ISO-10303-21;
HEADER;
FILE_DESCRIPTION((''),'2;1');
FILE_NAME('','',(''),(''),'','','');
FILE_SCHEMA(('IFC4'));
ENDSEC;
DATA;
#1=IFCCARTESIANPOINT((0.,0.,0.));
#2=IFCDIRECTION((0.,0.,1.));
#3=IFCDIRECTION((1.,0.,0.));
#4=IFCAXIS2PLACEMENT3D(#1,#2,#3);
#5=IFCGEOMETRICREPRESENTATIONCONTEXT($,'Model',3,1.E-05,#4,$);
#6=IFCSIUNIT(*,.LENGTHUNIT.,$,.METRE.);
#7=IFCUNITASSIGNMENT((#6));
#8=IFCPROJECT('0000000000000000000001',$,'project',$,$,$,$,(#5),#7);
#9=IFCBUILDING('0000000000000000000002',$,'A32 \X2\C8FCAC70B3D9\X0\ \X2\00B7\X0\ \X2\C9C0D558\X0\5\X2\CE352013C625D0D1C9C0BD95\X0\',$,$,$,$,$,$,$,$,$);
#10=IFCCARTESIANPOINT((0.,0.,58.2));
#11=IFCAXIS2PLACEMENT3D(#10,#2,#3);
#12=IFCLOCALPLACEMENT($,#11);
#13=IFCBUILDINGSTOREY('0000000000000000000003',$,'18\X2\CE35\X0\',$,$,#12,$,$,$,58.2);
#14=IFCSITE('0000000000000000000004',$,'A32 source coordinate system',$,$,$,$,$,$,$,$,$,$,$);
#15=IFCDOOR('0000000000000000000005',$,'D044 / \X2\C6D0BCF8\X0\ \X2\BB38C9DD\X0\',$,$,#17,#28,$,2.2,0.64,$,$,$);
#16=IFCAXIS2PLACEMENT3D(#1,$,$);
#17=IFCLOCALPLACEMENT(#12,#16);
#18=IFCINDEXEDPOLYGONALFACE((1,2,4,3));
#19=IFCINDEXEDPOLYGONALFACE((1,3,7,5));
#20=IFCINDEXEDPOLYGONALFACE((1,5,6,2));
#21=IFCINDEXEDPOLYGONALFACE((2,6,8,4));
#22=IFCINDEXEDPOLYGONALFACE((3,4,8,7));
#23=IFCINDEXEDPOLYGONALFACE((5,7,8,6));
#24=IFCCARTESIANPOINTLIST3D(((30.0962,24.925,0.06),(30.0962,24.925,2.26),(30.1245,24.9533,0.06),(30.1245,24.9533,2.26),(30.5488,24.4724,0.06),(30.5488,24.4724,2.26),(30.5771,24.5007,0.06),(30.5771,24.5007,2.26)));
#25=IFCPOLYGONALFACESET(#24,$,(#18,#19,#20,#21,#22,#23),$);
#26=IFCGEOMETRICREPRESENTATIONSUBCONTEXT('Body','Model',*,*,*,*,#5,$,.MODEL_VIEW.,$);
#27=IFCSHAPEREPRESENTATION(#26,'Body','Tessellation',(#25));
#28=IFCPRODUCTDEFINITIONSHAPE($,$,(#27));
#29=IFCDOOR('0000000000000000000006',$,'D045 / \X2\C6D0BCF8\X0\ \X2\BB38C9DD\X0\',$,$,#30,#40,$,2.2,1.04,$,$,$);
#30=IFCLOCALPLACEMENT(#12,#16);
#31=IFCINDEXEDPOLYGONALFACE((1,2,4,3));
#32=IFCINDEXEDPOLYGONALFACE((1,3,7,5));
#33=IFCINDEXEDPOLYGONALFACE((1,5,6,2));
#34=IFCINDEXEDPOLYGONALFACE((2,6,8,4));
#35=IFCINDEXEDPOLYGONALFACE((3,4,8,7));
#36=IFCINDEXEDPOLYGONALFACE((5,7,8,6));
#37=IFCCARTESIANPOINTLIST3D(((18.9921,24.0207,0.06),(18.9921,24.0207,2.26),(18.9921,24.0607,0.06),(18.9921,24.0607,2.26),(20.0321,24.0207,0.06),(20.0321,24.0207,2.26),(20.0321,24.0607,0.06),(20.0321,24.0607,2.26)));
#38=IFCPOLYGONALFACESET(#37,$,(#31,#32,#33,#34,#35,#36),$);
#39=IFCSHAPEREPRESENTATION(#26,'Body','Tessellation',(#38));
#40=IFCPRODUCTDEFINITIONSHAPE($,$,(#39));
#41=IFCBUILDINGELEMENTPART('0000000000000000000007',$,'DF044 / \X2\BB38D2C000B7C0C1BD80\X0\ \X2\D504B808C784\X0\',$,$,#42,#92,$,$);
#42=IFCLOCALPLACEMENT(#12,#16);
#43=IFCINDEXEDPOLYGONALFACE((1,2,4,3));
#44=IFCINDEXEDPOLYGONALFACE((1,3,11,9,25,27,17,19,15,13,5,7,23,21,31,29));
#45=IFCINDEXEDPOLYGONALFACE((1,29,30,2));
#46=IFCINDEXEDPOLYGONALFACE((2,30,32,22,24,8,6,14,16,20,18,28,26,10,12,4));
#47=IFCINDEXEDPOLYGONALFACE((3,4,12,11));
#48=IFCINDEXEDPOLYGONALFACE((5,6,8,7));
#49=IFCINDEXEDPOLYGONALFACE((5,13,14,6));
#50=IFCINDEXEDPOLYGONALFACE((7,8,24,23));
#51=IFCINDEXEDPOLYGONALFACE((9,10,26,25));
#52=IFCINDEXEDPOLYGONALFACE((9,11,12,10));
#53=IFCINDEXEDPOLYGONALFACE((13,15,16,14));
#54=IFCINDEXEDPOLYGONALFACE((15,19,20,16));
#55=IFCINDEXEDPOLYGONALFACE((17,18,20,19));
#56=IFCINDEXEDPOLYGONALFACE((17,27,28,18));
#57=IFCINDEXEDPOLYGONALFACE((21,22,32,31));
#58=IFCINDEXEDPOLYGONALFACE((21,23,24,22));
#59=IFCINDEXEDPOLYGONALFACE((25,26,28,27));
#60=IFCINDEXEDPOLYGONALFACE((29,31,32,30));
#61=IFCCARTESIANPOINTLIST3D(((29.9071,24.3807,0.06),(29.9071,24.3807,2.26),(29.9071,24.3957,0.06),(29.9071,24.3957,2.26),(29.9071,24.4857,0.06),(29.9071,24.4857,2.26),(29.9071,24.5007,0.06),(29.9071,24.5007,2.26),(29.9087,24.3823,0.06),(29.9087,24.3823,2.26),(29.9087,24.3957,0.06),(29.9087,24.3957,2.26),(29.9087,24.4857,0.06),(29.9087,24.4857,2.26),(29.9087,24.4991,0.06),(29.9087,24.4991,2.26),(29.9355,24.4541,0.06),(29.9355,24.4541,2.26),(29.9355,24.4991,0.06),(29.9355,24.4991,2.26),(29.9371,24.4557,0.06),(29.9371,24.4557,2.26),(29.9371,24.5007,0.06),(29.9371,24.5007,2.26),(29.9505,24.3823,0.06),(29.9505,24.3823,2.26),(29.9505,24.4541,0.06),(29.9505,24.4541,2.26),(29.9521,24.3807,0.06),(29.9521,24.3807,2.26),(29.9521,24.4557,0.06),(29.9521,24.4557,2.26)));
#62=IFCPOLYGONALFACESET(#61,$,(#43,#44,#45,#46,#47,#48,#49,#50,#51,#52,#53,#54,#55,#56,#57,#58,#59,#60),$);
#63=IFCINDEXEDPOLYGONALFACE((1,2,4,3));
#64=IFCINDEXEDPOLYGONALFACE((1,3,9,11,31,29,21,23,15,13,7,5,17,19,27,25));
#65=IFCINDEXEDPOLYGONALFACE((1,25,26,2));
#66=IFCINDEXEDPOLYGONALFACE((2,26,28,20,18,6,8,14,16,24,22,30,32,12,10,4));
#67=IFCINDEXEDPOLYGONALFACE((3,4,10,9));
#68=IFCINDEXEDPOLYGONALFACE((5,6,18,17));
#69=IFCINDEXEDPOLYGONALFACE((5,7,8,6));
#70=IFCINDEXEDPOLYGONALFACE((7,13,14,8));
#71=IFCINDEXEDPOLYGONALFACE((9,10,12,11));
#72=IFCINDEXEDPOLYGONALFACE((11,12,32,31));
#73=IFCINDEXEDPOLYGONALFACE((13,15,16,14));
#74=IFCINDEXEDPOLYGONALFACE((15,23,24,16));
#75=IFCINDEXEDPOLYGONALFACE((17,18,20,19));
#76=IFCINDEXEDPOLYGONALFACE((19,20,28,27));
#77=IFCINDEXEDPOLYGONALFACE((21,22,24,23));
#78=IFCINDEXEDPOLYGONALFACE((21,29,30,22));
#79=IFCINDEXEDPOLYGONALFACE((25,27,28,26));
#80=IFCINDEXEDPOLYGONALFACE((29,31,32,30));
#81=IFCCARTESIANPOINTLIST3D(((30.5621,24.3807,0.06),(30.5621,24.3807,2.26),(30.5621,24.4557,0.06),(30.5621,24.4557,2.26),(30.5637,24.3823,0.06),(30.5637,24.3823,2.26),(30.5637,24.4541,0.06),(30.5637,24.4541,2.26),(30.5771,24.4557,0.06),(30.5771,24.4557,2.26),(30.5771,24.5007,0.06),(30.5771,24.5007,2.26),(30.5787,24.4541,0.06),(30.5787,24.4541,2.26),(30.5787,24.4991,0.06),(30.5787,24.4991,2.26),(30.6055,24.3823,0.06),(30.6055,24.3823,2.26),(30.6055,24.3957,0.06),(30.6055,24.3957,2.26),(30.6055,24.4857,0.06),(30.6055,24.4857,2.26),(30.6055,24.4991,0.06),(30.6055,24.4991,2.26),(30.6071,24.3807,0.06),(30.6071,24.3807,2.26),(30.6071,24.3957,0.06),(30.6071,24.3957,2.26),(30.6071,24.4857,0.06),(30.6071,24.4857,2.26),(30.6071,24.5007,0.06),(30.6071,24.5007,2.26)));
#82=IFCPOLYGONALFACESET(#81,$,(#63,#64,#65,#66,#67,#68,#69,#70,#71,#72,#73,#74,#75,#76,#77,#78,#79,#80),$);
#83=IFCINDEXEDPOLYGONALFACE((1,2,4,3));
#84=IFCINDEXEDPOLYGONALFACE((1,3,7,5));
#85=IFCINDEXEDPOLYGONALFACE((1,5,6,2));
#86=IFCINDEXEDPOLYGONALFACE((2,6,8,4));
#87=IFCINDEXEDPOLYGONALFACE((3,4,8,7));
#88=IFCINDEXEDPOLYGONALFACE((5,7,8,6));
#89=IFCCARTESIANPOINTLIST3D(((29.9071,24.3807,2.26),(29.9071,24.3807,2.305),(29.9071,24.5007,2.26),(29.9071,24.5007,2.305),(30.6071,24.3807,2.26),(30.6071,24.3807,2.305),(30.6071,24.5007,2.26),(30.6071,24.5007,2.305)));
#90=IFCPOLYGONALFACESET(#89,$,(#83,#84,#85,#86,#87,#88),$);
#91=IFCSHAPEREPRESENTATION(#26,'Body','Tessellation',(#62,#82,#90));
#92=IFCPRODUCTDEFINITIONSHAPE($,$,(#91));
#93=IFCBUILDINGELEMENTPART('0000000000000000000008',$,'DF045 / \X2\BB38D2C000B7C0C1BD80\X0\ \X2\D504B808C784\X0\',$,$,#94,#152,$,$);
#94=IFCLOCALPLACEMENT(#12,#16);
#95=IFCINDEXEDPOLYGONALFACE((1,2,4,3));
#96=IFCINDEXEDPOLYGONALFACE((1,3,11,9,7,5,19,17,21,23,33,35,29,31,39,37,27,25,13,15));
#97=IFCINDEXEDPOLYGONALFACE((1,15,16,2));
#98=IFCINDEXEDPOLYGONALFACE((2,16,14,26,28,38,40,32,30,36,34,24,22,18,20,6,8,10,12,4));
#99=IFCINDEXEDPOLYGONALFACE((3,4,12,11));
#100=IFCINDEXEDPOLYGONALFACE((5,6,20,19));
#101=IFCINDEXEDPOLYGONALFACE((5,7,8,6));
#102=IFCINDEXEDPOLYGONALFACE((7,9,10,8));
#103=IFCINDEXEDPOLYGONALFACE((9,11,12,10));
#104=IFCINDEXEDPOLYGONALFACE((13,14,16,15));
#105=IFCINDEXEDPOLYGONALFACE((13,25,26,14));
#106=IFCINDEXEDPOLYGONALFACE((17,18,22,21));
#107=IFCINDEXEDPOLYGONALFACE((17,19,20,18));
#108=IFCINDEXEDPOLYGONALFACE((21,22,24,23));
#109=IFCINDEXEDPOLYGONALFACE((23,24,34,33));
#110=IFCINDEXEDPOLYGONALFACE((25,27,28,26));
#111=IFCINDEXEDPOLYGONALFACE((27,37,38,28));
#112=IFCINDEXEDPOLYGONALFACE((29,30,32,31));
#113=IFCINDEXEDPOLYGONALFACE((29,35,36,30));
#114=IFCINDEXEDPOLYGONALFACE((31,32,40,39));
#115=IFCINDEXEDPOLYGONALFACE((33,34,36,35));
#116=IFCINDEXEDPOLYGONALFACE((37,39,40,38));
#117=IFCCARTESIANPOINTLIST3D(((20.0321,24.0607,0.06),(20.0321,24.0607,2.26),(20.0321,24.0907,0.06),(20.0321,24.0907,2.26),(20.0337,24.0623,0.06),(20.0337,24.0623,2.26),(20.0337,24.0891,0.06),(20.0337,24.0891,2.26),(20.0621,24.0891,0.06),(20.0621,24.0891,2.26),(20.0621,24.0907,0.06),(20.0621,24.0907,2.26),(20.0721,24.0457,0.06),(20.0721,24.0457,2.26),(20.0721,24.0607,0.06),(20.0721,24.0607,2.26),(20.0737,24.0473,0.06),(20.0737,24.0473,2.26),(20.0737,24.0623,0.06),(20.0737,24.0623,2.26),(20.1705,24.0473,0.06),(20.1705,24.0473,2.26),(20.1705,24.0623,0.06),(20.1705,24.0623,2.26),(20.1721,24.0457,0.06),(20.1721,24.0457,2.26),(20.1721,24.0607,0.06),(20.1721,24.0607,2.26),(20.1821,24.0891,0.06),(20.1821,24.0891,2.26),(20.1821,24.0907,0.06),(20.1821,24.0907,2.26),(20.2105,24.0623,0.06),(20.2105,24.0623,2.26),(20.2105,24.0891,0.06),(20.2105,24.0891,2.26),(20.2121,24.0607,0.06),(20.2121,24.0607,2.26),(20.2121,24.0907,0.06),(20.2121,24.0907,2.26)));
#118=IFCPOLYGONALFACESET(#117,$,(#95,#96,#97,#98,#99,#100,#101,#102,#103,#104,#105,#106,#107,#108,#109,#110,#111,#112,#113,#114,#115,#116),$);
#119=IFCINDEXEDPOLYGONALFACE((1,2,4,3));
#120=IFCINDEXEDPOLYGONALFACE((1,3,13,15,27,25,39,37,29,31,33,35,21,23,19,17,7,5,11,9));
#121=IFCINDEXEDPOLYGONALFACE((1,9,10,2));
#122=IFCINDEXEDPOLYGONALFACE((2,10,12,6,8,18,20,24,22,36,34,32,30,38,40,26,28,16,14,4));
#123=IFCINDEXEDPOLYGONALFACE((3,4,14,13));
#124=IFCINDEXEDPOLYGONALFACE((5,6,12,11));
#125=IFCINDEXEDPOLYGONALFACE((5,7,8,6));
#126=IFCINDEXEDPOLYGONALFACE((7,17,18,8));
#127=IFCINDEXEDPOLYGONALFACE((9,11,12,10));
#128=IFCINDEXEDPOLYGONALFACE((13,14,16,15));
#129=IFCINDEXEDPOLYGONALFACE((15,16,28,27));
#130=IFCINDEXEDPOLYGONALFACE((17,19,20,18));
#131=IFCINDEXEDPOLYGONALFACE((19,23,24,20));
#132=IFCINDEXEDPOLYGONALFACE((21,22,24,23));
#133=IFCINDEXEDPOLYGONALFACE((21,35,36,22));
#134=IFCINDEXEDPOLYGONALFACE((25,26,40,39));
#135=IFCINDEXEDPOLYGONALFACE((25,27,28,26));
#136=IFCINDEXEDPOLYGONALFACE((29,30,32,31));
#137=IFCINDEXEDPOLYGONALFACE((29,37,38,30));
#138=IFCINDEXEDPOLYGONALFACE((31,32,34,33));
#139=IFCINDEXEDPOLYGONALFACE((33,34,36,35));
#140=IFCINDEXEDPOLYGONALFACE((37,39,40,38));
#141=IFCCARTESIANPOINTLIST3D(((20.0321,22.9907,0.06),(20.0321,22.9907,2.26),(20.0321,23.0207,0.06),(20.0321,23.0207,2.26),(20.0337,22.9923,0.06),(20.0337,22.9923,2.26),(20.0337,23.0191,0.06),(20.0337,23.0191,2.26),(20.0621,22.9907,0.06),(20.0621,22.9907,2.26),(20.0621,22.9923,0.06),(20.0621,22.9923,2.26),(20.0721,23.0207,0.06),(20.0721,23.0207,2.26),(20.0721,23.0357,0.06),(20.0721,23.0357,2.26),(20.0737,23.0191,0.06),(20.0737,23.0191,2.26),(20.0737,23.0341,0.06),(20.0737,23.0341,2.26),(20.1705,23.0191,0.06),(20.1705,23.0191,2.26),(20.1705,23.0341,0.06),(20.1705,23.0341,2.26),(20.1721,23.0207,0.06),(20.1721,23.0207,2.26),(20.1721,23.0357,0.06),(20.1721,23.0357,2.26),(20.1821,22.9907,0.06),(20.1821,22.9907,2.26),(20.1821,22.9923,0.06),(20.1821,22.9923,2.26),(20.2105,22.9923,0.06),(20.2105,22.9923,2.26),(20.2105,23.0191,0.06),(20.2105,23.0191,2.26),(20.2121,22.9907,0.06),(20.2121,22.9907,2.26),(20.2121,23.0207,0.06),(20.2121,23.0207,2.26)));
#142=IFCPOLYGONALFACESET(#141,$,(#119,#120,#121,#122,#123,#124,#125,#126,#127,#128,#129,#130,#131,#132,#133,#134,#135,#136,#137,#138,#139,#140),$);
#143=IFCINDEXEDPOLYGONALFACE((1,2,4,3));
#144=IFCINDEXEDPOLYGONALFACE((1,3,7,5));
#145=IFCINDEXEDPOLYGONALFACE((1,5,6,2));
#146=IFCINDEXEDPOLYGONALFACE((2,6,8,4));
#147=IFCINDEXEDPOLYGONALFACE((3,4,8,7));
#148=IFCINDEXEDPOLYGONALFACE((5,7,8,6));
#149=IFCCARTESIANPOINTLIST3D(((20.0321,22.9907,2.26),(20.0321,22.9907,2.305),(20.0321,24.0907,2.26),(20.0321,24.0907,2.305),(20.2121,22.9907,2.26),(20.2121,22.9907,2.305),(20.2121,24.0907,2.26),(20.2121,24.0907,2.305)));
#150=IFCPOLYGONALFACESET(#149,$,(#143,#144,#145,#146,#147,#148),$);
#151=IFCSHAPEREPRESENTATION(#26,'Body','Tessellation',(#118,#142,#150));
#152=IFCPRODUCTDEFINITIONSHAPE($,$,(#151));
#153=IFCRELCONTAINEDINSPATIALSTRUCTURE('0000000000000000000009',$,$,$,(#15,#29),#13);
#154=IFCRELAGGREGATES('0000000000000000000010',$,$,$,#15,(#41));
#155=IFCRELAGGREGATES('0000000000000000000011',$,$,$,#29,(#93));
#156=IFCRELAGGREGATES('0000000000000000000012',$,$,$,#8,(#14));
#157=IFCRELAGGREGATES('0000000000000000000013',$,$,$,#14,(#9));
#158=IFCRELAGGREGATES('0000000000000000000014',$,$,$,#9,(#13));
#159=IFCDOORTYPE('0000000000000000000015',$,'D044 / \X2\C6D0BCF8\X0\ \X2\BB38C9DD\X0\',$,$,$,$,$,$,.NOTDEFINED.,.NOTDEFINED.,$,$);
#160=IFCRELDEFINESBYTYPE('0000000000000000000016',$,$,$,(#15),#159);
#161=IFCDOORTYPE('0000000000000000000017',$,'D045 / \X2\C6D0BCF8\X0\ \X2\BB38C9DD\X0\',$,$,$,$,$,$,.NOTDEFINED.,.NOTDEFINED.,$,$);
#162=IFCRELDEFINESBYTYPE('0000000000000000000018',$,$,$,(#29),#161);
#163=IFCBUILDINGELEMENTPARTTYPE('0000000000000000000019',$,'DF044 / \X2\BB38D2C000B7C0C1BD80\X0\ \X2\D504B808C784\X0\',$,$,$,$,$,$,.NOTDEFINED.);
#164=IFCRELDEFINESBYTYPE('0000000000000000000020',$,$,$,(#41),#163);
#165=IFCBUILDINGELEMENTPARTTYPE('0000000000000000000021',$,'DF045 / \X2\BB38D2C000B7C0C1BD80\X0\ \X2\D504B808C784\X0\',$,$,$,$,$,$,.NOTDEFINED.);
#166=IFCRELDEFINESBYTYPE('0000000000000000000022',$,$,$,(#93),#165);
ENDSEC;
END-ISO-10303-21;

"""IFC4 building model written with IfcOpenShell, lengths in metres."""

from ifc_helpers import new_model, si_unit, frame, origin, origin_with_axes, place, context, subcontext, project, spatial, polyline, outline, extrude, source, transform, mapped, type_object, type_shapes, element, aggregate, save


model = new_model("IFC4")

# Units and contexts
model_context = context("Model", 3, precision=1e-05, world=origin_with_axes())
body_context = subcontext(model_context, "Body", "Model", "MODEL_VIEW")
ifc_project = project(units=[si_unit("LENGTHUNIT", "METRE")], contexts=[model_context])

# Site, building, storey
storey_placement = place(None, frame((0.0, 0.0, 58.2), z_axis=(0.0, 0.0, 1.0), x_axis=(1.0, 0.0, 0.0)))
site = spatial("IfcSite", under=ifc_project, Name="A32 source coordinate system")
building = spatial("IfcBuilding", under=site, Name="A32 주거동 · 지하5층–옥탑지붕")
storey = spatial("IfcBuildingStorey", under=building, at=storey_placement, Name="18층", Elevation=58.2)

# Doors
door_type_1 = type_object("IfcDoorType", Name="D044 / 원본 문짝", OperationType="NOTDEFINED", PredefinedType="NOTDEFINED")
shared_shape_1 = source(origin(), body_context, "Body", "SweptSolid", [
    extrude(outline(polyline([(30.5771, 24.5007), (30.5488, 24.4724), (30.0962, 24.925), (30.1245, 24.9533), (30.5771, 24.5007)])), frame((0.0, 0.0, 0.06)), (0.0, 0.0, 1.0), 2.2),
])
type_shapes(door_type_1, [shared_shape_1])
door_1_placement = place(storey_placement, origin_with_axes())
door_1 = element("IfcDoor", 1, at=door_1_placement, inside=storey, type_object=door_type_1, Name="D044 / 원본 문짝", OverallHeight=2.2, OverallWidth=0.64, context=body_context, shape_type="MappedRepresentation", body=[
    mapped(shared_shape_1, transform((0.0, 0.0, 0.0), scale=1.0)),
])
door_type_2 = type_object("IfcDoorType", Name="D045 / 원본 문짝", OperationType="NOTDEFINED", PredefinedType="NOTDEFINED")
shared_shape_2 = source(origin(), body_context, "Body", "SweptSolid", [
    extrude(outline(polyline([(20.0321, 24.0607), (20.0321, 24.0207), (18.9921, 24.0207), (18.9921, 24.0607), (20.0321, 24.0607)])), frame((0.0, 0.0, 0.06)), (0.0, 0.0, 1.0), 2.2),
])
type_shapes(door_type_2, [shared_shape_2])
door_2_placement = place(storey_placement, origin_with_axes())
door_2 = element("IfcDoor", 2, at=door_2_placement, inside=storey, type_object=door_type_2, Name="D045 / 원본 문짝", OverallHeight=2.2, OverallWidth=1.04, context=body_context, shape_type="MappedRepresentation", body=[
    mapped(shared_shape_2, transform((0.0, 0.0, 0.0), scale=1.0)),
])

# Building element parts
building_element_part_type_1 = type_object("IfcBuildingElementPartType", Name="DF044 / 문틀·상부 프레임", PredefinedType="NOTDEFINED")
shared_shape_3 = source(origin(), body_context, "Body", "SweptSolid", [
    extrude(outline(polyline([(29.9071, 24.4857), (29.9071, 24.5007), (29.9371, 24.5007), (29.9371, 24.4557), (29.9521, 24.4557), (29.9521, 24.3807), (29.9071, 24.3807), (29.9071, 24.3957), (29.9087, 24.3957), (29.9087, 24.3823), (29.9505, 24.3823), (29.9505, 24.4541), (29.9355, 24.4541), (29.9355, 24.4991), (29.9087, 24.4991), (29.9087, 24.4857), (29.9071, 24.4857)])), frame((0.0, 0.0, 0.06)), (0.0, 0.0, 1.0), 2.2),
    extrude(outline(polyline([(30.6055, 24.4991), (30.5787, 24.4991), (30.5787, 24.4541), (30.5637, 24.4541), (30.5637, 24.3823), (30.6055, 24.3823), (30.6055, 24.3957), (30.6071, 24.3957), (30.6071, 24.3807), (30.5621, 24.3807), (30.5621, 24.4557), (30.5771, 24.4557), (30.5771, 24.5007), (30.6071, 24.5007), (30.6071, 24.4857), (30.6055, 24.4857), (30.6055, 24.4991)])), frame((0.0, 0.0, 0.06)), (0.0, 0.0, 1.0), 2.2),
    extrude(outline(polyline([(29.9071, 24.3807), (29.9071, 24.5007), (30.6071, 24.5007), (30.6071, 24.3807), (29.9071, 24.3807)])), frame((0.0, 0.0, 2.26)), (0.0, 0.0, 1.0), 0.045),
])
type_shapes(building_element_part_type_1, [shared_shape_3])
building_element_part_1_placement = place(door_1_placement, origin_with_axes())
building_element_part_1 = element("IfcBuildingElementPart", 3, at=building_element_part_1_placement, type_object=building_element_part_type_1, Name="DF044 / 문틀·상부 프레임", context=body_context, shape_type="MappedRepresentation", body=[
    mapped(shared_shape_3, transform((0.0, 0.0, 0.0), scale=1.0)),
])
aggregate(door_1, [building_element_part_1])
building_element_part_type_2 = type_object("IfcBuildingElementPartType", Name="DF045 / 문틀·상부 프레임", PredefinedType="NOTDEFINED")
shared_shape_4 = source(origin(), body_context, "Body", "SweptSolid", [
    extrude(outline(polyline([(20.0337, 24.0891), (20.0337, 24.0623), (20.0737, 24.0623), (20.0737, 24.0473), (20.1705, 24.0473), (20.1705, 24.0623), (20.2105, 24.0623), (20.2105, 24.0891), (20.1821, 24.0891), (20.1821, 24.0907), (20.2121, 24.0907), (20.2121, 24.0607), (20.1721, 24.0607), (20.1721, 24.0457), (20.0721, 24.0457), (20.0721, 24.0607), (20.0321, 24.0607), (20.0321, 24.0907), (20.0621, 24.0907), (20.0621, 24.0891), (20.0337, 24.0891)])), frame((0.0, 0.0, 0.06)), (0.0, 0.0, 1.0), 2.2),
    extrude(outline(polyline([(20.0621, 22.9907), (20.0321, 22.9907), (20.0321, 23.0207), (20.0721, 23.0207), (20.0721, 23.0357), (20.1721, 23.0357), (20.1721, 23.0207), (20.2121, 23.0207), (20.2121, 22.9907), (20.1821, 22.9907), (20.1821, 22.9923), (20.2105, 22.9923), (20.2105, 23.0191), (20.1705, 23.0191), (20.1705, 23.0341), (20.0737, 23.0341), (20.0737, 23.0191), (20.0337, 23.0191), (20.0337, 22.9923), (20.0621, 22.9923), (20.0621, 22.9907)])), frame((0.0, 0.0, 0.06)), (0.0, 0.0, 1.0), 2.2),
    extrude(outline(polyline([(20.0321, 22.9907), (20.0321, 24.0907), (20.2121, 24.0907), (20.2121, 22.9907), (20.0321, 22.9907)])), frame((0.0, 0.0, 2.26)), (0.0, 0.0, 1.0), 0.045),
])
type_shapes(building_element_part_type_2, [shared_shape_4])
building_element_part_2_placement = place(door_2_placement, origin_with_axes())
building_element_part_2 = element("IfcBuildingElementPart", 4, at=building_element_part_2_placement, type_object=building_element_part_type_2, Name="DF045 / 문틀·상부 프레임", context=body_context, shape_type="MappedRepresentation", body=[
    mapped(shared_shape_4, transform((0.0, 0.0, 0.0), scale=1.0)),
])
aggregate(door_2, [building_element_part_2])

save(model, "model.ifc")
